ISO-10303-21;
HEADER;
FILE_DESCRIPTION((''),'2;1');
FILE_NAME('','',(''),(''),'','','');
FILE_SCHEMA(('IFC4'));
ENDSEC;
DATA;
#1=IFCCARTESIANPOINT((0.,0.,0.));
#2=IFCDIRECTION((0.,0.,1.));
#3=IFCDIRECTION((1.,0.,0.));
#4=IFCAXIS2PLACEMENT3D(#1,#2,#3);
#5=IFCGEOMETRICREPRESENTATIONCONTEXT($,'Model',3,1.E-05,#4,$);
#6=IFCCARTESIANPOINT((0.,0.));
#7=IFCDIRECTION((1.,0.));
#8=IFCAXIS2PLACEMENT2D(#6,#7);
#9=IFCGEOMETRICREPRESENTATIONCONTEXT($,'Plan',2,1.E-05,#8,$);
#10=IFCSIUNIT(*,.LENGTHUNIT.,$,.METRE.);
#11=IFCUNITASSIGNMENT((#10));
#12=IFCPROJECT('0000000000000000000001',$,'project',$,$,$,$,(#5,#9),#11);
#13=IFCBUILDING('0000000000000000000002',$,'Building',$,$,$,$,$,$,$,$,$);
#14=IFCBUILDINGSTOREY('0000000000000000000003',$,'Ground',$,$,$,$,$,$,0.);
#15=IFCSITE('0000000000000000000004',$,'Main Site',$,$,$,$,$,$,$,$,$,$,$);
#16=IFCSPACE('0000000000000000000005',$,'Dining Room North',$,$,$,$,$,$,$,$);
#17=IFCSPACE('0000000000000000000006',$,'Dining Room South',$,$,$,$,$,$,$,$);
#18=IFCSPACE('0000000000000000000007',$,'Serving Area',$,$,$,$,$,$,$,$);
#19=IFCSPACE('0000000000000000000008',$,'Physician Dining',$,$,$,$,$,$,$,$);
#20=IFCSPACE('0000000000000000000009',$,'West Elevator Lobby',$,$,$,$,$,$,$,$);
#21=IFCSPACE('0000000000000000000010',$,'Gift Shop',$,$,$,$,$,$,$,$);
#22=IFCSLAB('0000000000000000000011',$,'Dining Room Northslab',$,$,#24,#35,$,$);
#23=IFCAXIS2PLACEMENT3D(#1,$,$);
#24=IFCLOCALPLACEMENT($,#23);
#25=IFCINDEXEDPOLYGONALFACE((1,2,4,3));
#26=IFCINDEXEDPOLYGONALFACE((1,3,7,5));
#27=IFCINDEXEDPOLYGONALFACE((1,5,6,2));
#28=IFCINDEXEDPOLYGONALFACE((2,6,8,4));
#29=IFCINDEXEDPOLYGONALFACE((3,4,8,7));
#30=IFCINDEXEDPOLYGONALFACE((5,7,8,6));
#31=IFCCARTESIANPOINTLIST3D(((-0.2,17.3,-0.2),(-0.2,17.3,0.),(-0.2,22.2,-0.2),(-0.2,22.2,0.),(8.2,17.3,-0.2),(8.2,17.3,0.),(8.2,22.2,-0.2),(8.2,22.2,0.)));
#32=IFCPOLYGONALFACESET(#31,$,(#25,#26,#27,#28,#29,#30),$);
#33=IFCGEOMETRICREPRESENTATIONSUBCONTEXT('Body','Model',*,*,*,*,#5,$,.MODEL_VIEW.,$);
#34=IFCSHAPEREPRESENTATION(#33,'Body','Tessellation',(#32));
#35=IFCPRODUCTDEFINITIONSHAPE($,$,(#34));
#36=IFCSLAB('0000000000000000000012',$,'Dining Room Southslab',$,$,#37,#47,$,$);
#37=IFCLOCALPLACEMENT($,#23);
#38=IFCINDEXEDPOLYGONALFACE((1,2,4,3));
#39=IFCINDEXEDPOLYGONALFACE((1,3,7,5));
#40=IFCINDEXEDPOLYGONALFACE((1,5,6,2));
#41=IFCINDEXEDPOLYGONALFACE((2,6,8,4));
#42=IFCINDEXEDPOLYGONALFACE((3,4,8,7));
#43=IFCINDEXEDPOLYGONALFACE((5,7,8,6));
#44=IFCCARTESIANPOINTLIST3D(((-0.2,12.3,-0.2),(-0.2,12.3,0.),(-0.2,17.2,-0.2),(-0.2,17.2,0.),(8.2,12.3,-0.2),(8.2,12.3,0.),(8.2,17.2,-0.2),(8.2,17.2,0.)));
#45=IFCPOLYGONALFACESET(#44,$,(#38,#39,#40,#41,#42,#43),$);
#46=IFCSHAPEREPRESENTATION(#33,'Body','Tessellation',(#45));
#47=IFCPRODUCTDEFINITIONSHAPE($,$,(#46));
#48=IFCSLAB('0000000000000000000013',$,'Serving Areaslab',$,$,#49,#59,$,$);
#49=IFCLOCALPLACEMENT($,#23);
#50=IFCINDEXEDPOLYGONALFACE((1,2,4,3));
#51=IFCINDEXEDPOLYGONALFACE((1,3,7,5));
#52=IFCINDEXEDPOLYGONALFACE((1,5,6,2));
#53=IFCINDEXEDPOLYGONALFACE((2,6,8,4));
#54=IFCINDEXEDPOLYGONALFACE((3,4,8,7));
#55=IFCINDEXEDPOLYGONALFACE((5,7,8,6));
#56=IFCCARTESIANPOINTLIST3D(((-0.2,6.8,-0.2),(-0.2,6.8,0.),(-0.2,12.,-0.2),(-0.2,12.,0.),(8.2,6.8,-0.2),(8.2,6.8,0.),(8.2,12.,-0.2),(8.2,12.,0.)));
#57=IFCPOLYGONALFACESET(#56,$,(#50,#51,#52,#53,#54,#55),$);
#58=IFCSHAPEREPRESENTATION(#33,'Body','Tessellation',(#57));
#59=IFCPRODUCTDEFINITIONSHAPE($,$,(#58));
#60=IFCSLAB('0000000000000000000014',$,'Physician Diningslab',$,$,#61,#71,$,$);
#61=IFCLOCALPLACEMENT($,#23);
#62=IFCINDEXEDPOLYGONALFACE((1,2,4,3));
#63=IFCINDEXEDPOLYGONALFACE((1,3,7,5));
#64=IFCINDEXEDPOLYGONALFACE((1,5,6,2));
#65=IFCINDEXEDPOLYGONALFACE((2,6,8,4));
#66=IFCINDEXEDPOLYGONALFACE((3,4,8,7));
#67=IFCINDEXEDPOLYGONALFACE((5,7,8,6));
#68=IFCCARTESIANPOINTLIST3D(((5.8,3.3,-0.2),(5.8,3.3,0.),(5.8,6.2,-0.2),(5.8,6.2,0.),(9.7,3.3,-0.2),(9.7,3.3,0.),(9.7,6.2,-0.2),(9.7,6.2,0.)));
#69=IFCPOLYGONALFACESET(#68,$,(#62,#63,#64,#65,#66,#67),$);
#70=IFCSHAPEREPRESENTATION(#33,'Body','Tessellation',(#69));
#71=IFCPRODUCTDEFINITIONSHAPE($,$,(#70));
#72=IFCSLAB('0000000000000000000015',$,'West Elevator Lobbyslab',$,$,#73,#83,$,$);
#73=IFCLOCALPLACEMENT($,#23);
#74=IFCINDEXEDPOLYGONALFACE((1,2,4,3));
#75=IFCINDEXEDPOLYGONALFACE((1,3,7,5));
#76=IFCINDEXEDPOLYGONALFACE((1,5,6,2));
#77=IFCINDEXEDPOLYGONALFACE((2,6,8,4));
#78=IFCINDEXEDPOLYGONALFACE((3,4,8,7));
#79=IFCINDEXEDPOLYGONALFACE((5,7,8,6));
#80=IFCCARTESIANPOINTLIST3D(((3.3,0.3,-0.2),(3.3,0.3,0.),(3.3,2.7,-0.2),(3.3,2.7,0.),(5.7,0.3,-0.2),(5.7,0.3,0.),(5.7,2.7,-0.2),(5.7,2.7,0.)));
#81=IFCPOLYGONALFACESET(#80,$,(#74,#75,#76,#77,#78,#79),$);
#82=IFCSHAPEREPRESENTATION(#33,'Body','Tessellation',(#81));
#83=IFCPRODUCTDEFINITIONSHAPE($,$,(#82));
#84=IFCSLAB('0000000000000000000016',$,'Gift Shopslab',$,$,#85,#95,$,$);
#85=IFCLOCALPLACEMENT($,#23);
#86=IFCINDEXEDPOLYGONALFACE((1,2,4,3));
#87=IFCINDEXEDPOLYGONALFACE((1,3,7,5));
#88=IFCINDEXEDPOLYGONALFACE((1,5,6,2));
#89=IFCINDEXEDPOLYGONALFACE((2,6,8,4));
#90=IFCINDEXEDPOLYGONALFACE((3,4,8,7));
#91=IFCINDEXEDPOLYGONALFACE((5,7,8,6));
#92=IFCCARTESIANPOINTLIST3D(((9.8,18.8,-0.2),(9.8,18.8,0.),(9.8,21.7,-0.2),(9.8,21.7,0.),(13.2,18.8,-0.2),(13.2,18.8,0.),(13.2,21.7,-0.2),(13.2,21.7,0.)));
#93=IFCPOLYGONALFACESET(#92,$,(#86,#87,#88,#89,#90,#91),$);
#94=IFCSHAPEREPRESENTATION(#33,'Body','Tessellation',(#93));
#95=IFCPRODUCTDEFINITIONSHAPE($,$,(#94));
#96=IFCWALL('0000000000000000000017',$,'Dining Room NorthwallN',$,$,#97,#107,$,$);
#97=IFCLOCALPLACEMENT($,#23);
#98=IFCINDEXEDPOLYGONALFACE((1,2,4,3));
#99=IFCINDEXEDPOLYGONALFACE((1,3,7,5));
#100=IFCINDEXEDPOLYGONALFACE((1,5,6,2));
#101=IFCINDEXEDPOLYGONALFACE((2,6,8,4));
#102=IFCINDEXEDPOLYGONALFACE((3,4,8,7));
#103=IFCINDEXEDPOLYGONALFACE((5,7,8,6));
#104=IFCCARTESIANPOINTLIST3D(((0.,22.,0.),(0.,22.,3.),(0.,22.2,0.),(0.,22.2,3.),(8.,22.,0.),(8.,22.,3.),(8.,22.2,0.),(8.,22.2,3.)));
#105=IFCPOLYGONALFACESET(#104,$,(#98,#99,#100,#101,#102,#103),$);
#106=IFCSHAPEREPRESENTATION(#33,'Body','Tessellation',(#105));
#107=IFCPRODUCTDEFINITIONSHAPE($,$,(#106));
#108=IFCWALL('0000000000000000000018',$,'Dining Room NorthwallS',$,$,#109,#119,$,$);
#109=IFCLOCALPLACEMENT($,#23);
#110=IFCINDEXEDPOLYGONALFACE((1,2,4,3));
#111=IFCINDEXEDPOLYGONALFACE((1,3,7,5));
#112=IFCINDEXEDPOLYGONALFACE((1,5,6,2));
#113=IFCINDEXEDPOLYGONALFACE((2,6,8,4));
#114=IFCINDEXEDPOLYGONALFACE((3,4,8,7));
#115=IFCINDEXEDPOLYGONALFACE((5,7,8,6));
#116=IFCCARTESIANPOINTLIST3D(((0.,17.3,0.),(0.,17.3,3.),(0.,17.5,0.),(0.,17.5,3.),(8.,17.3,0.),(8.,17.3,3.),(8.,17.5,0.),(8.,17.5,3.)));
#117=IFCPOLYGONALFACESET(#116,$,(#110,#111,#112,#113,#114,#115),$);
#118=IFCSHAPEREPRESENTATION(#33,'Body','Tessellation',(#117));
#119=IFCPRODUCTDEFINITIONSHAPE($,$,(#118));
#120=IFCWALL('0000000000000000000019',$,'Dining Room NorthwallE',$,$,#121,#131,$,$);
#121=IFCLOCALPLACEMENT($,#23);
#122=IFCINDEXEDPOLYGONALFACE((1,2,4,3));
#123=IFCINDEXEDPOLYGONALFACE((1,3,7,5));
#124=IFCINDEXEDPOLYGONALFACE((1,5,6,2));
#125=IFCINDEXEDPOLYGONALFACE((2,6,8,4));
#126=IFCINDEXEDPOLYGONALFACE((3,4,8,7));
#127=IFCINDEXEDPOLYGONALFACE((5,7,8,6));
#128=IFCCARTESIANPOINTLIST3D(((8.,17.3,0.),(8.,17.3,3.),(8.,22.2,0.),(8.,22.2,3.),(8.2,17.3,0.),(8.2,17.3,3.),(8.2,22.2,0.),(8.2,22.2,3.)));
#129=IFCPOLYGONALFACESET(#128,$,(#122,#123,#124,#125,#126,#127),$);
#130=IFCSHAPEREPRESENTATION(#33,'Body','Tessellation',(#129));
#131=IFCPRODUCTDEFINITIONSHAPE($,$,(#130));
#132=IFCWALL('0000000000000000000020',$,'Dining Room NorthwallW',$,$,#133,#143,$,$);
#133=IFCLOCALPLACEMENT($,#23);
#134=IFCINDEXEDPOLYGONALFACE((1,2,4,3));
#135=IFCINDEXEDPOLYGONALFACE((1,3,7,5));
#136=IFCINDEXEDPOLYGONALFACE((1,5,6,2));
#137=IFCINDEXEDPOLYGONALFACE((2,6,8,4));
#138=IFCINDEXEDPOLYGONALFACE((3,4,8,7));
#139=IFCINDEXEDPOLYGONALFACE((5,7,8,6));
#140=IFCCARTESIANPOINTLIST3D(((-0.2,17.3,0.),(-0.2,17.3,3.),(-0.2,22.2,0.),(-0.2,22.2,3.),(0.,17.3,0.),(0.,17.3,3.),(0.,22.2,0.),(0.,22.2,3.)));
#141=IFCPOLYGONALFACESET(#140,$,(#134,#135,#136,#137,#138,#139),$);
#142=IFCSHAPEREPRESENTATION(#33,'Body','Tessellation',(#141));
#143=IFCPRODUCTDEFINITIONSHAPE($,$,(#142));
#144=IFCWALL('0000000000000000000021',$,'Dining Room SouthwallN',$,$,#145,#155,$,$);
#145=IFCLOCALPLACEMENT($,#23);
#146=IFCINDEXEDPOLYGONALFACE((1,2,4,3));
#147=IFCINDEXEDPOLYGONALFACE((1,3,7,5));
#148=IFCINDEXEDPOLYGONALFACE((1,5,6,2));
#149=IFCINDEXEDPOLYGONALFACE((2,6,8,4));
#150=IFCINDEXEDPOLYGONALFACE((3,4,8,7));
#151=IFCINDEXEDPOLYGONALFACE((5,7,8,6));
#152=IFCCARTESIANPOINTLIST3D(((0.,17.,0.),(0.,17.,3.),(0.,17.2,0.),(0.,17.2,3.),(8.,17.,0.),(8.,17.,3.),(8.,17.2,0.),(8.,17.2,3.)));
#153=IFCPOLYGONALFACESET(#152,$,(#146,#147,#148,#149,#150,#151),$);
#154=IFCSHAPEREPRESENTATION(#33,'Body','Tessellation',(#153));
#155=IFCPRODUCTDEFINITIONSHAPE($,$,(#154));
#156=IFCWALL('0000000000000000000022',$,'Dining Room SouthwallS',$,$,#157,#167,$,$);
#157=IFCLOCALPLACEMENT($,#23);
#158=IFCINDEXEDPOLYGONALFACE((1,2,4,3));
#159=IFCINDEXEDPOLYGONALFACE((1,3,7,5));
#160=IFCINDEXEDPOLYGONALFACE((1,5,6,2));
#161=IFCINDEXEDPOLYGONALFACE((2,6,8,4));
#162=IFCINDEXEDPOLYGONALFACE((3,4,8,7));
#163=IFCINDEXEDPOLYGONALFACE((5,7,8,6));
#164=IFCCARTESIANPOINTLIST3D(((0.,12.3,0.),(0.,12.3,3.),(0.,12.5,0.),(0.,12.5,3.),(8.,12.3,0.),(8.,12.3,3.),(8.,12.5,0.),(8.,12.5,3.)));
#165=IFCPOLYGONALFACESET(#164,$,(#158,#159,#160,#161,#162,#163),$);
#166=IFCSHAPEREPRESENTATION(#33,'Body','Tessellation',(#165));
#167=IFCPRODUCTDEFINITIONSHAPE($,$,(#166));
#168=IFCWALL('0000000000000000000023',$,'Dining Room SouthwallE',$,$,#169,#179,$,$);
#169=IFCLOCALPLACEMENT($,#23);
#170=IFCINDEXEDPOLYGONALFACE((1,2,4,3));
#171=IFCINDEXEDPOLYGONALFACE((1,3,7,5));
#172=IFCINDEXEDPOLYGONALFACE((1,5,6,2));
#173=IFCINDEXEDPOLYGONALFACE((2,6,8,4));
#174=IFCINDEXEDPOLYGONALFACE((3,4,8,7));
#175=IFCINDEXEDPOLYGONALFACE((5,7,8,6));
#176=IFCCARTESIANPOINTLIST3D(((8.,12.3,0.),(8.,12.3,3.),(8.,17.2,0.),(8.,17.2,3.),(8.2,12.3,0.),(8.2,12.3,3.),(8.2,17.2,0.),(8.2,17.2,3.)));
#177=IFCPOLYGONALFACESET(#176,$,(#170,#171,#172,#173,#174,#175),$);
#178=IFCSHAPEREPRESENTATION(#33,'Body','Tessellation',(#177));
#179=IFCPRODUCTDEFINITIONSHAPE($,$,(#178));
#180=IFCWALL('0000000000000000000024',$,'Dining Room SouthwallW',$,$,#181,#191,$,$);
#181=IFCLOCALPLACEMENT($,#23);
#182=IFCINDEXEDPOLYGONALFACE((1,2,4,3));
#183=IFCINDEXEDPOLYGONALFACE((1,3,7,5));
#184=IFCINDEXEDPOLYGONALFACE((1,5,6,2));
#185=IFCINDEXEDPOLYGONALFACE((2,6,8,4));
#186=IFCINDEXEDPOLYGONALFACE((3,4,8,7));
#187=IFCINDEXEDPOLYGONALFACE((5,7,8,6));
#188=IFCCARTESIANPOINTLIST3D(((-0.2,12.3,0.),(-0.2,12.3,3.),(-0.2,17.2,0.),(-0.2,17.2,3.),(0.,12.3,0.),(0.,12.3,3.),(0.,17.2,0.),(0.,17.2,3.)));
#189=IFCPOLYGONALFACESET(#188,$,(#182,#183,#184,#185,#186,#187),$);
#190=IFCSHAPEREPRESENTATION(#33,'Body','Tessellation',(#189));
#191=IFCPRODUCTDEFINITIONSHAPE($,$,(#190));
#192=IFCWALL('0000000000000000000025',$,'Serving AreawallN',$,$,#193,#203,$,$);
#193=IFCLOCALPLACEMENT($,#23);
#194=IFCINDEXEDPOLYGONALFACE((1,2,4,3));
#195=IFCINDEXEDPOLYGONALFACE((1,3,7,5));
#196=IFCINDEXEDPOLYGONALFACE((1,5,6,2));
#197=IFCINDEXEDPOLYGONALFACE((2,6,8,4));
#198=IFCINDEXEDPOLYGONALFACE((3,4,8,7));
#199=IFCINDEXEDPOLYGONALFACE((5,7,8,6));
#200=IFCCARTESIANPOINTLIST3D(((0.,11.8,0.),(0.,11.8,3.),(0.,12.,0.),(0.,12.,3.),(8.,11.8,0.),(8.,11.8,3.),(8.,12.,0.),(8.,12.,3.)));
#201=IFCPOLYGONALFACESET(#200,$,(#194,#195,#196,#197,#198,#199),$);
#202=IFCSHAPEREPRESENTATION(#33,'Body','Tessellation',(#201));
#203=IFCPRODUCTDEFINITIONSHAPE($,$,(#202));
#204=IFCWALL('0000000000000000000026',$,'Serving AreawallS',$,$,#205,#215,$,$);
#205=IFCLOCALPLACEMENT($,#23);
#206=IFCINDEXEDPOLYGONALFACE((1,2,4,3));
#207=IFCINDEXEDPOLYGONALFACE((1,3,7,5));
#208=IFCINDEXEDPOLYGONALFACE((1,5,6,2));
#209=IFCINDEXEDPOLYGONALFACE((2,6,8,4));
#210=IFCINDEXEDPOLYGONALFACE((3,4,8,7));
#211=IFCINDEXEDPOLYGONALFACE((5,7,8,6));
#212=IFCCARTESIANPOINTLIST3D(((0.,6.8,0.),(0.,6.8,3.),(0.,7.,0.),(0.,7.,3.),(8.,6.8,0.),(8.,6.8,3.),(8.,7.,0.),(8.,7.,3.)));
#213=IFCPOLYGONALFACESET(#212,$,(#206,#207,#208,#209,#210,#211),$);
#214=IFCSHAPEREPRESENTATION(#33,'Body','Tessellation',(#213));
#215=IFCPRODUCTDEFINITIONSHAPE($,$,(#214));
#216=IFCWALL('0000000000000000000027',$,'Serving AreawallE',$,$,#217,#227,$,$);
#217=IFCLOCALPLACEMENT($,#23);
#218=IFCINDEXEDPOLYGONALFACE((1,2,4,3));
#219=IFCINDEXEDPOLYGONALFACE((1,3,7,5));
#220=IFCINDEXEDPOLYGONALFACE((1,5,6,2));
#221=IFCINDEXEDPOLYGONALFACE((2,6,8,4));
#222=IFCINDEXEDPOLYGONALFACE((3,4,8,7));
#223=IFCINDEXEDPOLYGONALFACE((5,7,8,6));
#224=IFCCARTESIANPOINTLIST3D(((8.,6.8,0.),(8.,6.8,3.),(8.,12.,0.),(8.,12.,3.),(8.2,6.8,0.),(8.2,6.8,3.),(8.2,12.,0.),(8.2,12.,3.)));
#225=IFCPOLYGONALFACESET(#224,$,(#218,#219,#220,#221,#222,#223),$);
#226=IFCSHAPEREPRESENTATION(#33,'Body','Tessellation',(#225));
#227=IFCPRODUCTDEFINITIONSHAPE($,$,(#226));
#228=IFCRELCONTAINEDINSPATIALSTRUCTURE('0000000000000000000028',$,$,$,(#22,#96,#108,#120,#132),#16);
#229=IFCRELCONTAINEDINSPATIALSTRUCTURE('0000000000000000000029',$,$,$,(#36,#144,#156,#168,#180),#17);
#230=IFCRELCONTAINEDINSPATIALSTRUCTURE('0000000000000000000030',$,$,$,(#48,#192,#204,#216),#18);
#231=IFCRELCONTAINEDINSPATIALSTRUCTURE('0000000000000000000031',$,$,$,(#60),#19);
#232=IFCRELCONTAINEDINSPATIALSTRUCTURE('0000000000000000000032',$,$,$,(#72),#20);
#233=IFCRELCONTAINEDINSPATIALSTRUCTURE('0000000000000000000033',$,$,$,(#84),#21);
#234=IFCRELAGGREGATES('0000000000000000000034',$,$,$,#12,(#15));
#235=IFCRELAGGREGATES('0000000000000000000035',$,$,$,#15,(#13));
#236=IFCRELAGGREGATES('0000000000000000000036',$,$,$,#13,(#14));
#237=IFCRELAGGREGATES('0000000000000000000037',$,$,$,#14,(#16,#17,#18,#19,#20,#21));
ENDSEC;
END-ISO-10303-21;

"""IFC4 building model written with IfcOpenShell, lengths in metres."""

from ifc_helpers import new_model, si_unit, frame, origin_with_axes, origin_2d_with_axis, place, context, subcontext, project, spatial, indexed_curve, rectangle, outline, extrude, element, save


model = new_model("IFC4")

# Units and contexts
model_context = context("Model", 3, precision=1e-05, world=origin_with_axes())
plan_context = context("Plan", 2, precision=1e-05, world=origin_2d_with_axis())
body_context = subcontext(model_context, "Body", "Model", "MODEL_VIEW")
ifc_project = project(units=[si_unit("LENGTHUNIT", "METRE")], contexts=[model_context, plan_context])

# Site, building, storey, space
site = spatial("IfcSite", under=ifc_project, Name="Main Site")
building = spatial("IfcBuilding", under=site, Name="Building")
storey = spatial("IfcBuildingStorey", under=building, Name="Ground", Elevation=0.0)
space_1 = spatial("IfcSpace", under=storey, Name="Dining Room North")

# Slab
slab_1_placement = place(None, frame((4.0, 19.75, -0.2), z_axis=(0.0, 0.0, 1.0), x_axis=(1.0, 0.0, 0.0)))
element("IfcSlab", 1, at=slab_1_placement, inside=space_1, Name="Dining Room Northslab", context=body_context, shape_type="SweptSolid", body=[
    extrude(rectangle(XDim=8.4, YDim=4.9), origin_with_axes(), (0.0, 0.0, 1.0), 0.2),
])

# Shared definitions
space_2 = spatial("IfcSpace", under=storey, Name="Dining Room South")

# Slab
slab_2_placement = place(None, frame((4.0, 14.75, -0.2), z_axis=(0.0, 0.0, 1.0), x_axis=(1.0, 0.0, 0.0)))
element("IfcSlab", 2, at=slab_2_placement, inside=space_2, Name="Dining Room Southslab", context=body_context, shape_type="SweptSolid", body=[
    extrude(rectangle(XDim=8.4, YDim=4.9), origin_with_axes(), (0.0, 0.0, 1.0), 0.2),
])

# Shared definitions
space_3 = spatial("IfcSpace", under=storey, Name="Serving Area")

# Slab
slab_3_placement = place(None, frame((4.0, 9.4, -0.2), z_axis=(0.0, 0.0, 1.0), x_axis=(1.0, 0.0, 0.0)))
element("IfcSlab", 3, at=slab_3_placement, inside=space_3, Name="Serving Areaslab", context=body_context, shape_type="SweptSolid", body=[
    extrude(rectangle(XDim=8.4, YDim=5.2), origin_with_axes(), (0.0, 0.0, 1.0), 0.2),
])

# Shared definitions
space_4 = spatial("IfcSpace", under=storey, Name="Physician Dining")

# Slab
slab_4_placement = place(None, frame((7.75, 4.75, -0.2), z_axis=(0.0, 0.0, 1.0), x_axis=(1.0, 0.0, 0.0)))
element("IfcSlab", 4, at=slab_4_placement, inside=space_4, Name="Physician Diningslab", context=body_context, shape_type="SweptSolid", body=[
    extrude(rectangle(XDim=3.9, YDim=2.9), origin_with_axes(), (0.0, 0.0, 1.0), 0.2),
])

# Shared definitions
space_5 = spatial("IfcSpace", under=storey, Name="West Elevator Lobby")

# Slab
slab_5_placement = place(None, frame((4.5, 1.5, -0.2), z_axis=(0.0, 0.0, 1.0), x_axis=(1.0, 0.0, 0.0)))
element("IfcSlab", 5, at=slab_5_placement, inside=space_5, Name="West Elevator Lobbyslab", context=body_context, shape_type="SweptSolid", body=[
    extrude(rectangle(XDim=2.4, YDim=2.4), origin_with_axes(), (0.0, 0.0, 1.0), 0.2),
])

# Shared definitions
space_6 = spatial("IfcSpace", under=storey, Name="Gift Shop")

# Slab
slab_6_placement = place(None, frame((11.5, 20.25, -0.2), z_axis=(0.0, 0.0, 1.0), x_axis=(1.0, 0.0, 0.0)))
element("IfcSlab", 6, at=slab_6_placement, inside=space_6, Name="Gift Shopslab", context=body_context, shape_type="SweptSolid", body=[
    extrude(rectangle(XDim=3.4, YDim=2.9), origin_with_axes(), (0.0, 0.0, 1.0), 0.2),
])

# Walls
for number, where, z_axis, x_axis, name in (
    (7, (0.0, 22.0, 0.0), (0.0, 0.0, 1.0), (1.0, 0.0, 0.0), "Dining Room NorthwallN"),
    (8, (0.0, 17.3, 0.0), (0.0, 0.0, 1.0), (1.0, 0.0, 0.0), "Dining Room NorthwallS"),
):
    element("IfcWall", number, at=place(None, frame(where, z_axis=z_axis, x_axis=x_axis)), inside=space_1, Name=name, context=body_context, shape_type="SweptSolid", body=[
        extrude(outline(indexed_curve([(0.0, 0.0), (0.0, 0.2), (8.0, 0.2), (8.0, 0.0), (0.0, 0.0)], self_intersect=False)), origin_with_axes(), (0.0, 0.0, 1.0), 3.0),
    ])
for number, where, z_axis, x_axis, name in (
    (9, (8.2, 17.3, 0.0), (0.0, 0.0, 1.0), (0.0, 1.0, 0.0), "Dining Room NorthwallE"),
    (10, (0.0, 17.3, 0.0), (0.0, 0.0, 1.0), (0.0, 1.0, 0.0), "Dining Room NorthwallW"),
):
    element("IfcWall", number, at=place(None, frame(where, z_axis=z_axis, x_axis=x_axis)), inside=space_1, Name=name, context=body_context, shape_type="SweptSolid", body=[
        extrude(outline(indexed_curve([(0.0, 0.0), (0.0, 0.2), (4.9, 0.2), (4.9, 0.0), (0.0, 0.0)], self_intersect=False)), origin_with_axes(), (0.0, 0.0, 1.0), 3.0),
    ])
for number, where, z_axis, x_axis, name in (
    (11, (0.0, 17.0, 0.0), (0.0, 0.0, 1.0), (1.0, 0.0, 0.0), "Dining Room SouthwallN"),
    (12, (0.0, 12.3, 0.0), (0.0, 0.0, 1.0), (1.0, 0.0, 0.0), "Dining Room SouthwallS"),
):
    element("IfcWall", number, at=place(None, frame(where, z_axis=z_axis, x_axis=x_axis)), inside=space_2, Name=name, context=body_context, shape_type="SweptSolid", body=[
        extrude(outline(indexed_curve([(0.0, 0.0), (0.0, 0.2), (8.0, 0.2), (8.0, 0.0), (0.0, 0.0)], self_intersect=False)), origin_with_axes(), (0.0, 0.0, 1.0), 3.0),
    ])
for number, where, z_axis, x_axis, name in (
    (13, (8.2, 12.3, 0.0), (0.0, 0.0, 1.0), (0.0, 1.0, 0.0), "Dining Room SouthwallE"),
    (14, (0.0, 12.3, 0.0), (0.0, 0.0, 1.0), (0.0, 1.0, 0.0), "Dining Room SouthwallW"),
):
    element("IfcWall", number, at=place(None, frame(where, z_axis=z_axis, x_axis=x_axis)), inside=space_2, Name=name, context=body_context, shape_type="SweptSolid", body=[
        extrude(outline(indexed_curve([(0.0, 0.0), (0.0, 0.2), (4.9, 0.2), (4.9, 0.0), (0.0, 0.0)], self_intersect=False)), origin_with_axes(), (0.0, 0.0, 1.0), 3.0),
    ])
for number, where, z_axis, x_axis, name in (
    (15, (0.0, 11.8, 0.0), (0.0, 0.0, 1.0), (1.0, 0.0, 0.0), "Serving AreawallN"),
    (16, (0.0, 6.8, 0.0), (0.0, 0.0, 1.0), (1.0, 0.0, 0.0), "Serving AreawallS"),
):
    element("IfcWall", number, at=place(None, frame(where, z_axis=z_axis, x_axis=x_axis)), inside=space_3, Name=name, context=body_context, shape_type="SweptSolid", body=[
        extrude(outline(indexed_curve([(0.0, 0.0), (0.0, 0.2), (8.0, 0.2), (8.0, 0.0), (0.0, 0.0)], self_intersect=False)), origin_with_axes(), (0.0, 0.0, 1.0), 3.0),
    ])
for number, where, z_axis, x_axis, name in (
    (17, (8.2, 6.8, 0.0), (0.0, 0.0, 1.0), (0.0, 1.0, 0.0), "Serving AreawallE"),
):
    element("IfcWall", number, at=place(None, frame(where, z_axis=z_axis, x_axis=x_axis)), inside=space_3, Name=name, context=body_context, shape_type="SweptSolid", body=[
        extrude(outline(indexed_curve([(0.0, 0.0), (0.0, 0.2), (5.2, 0.2), (5.2, 0.0), (0.0, 0.0)], self_intersect=False)), origin_with_axes(), (0.0, 0.0, 1.0), 3.0),
    ])

save(model, "model.ifc")
